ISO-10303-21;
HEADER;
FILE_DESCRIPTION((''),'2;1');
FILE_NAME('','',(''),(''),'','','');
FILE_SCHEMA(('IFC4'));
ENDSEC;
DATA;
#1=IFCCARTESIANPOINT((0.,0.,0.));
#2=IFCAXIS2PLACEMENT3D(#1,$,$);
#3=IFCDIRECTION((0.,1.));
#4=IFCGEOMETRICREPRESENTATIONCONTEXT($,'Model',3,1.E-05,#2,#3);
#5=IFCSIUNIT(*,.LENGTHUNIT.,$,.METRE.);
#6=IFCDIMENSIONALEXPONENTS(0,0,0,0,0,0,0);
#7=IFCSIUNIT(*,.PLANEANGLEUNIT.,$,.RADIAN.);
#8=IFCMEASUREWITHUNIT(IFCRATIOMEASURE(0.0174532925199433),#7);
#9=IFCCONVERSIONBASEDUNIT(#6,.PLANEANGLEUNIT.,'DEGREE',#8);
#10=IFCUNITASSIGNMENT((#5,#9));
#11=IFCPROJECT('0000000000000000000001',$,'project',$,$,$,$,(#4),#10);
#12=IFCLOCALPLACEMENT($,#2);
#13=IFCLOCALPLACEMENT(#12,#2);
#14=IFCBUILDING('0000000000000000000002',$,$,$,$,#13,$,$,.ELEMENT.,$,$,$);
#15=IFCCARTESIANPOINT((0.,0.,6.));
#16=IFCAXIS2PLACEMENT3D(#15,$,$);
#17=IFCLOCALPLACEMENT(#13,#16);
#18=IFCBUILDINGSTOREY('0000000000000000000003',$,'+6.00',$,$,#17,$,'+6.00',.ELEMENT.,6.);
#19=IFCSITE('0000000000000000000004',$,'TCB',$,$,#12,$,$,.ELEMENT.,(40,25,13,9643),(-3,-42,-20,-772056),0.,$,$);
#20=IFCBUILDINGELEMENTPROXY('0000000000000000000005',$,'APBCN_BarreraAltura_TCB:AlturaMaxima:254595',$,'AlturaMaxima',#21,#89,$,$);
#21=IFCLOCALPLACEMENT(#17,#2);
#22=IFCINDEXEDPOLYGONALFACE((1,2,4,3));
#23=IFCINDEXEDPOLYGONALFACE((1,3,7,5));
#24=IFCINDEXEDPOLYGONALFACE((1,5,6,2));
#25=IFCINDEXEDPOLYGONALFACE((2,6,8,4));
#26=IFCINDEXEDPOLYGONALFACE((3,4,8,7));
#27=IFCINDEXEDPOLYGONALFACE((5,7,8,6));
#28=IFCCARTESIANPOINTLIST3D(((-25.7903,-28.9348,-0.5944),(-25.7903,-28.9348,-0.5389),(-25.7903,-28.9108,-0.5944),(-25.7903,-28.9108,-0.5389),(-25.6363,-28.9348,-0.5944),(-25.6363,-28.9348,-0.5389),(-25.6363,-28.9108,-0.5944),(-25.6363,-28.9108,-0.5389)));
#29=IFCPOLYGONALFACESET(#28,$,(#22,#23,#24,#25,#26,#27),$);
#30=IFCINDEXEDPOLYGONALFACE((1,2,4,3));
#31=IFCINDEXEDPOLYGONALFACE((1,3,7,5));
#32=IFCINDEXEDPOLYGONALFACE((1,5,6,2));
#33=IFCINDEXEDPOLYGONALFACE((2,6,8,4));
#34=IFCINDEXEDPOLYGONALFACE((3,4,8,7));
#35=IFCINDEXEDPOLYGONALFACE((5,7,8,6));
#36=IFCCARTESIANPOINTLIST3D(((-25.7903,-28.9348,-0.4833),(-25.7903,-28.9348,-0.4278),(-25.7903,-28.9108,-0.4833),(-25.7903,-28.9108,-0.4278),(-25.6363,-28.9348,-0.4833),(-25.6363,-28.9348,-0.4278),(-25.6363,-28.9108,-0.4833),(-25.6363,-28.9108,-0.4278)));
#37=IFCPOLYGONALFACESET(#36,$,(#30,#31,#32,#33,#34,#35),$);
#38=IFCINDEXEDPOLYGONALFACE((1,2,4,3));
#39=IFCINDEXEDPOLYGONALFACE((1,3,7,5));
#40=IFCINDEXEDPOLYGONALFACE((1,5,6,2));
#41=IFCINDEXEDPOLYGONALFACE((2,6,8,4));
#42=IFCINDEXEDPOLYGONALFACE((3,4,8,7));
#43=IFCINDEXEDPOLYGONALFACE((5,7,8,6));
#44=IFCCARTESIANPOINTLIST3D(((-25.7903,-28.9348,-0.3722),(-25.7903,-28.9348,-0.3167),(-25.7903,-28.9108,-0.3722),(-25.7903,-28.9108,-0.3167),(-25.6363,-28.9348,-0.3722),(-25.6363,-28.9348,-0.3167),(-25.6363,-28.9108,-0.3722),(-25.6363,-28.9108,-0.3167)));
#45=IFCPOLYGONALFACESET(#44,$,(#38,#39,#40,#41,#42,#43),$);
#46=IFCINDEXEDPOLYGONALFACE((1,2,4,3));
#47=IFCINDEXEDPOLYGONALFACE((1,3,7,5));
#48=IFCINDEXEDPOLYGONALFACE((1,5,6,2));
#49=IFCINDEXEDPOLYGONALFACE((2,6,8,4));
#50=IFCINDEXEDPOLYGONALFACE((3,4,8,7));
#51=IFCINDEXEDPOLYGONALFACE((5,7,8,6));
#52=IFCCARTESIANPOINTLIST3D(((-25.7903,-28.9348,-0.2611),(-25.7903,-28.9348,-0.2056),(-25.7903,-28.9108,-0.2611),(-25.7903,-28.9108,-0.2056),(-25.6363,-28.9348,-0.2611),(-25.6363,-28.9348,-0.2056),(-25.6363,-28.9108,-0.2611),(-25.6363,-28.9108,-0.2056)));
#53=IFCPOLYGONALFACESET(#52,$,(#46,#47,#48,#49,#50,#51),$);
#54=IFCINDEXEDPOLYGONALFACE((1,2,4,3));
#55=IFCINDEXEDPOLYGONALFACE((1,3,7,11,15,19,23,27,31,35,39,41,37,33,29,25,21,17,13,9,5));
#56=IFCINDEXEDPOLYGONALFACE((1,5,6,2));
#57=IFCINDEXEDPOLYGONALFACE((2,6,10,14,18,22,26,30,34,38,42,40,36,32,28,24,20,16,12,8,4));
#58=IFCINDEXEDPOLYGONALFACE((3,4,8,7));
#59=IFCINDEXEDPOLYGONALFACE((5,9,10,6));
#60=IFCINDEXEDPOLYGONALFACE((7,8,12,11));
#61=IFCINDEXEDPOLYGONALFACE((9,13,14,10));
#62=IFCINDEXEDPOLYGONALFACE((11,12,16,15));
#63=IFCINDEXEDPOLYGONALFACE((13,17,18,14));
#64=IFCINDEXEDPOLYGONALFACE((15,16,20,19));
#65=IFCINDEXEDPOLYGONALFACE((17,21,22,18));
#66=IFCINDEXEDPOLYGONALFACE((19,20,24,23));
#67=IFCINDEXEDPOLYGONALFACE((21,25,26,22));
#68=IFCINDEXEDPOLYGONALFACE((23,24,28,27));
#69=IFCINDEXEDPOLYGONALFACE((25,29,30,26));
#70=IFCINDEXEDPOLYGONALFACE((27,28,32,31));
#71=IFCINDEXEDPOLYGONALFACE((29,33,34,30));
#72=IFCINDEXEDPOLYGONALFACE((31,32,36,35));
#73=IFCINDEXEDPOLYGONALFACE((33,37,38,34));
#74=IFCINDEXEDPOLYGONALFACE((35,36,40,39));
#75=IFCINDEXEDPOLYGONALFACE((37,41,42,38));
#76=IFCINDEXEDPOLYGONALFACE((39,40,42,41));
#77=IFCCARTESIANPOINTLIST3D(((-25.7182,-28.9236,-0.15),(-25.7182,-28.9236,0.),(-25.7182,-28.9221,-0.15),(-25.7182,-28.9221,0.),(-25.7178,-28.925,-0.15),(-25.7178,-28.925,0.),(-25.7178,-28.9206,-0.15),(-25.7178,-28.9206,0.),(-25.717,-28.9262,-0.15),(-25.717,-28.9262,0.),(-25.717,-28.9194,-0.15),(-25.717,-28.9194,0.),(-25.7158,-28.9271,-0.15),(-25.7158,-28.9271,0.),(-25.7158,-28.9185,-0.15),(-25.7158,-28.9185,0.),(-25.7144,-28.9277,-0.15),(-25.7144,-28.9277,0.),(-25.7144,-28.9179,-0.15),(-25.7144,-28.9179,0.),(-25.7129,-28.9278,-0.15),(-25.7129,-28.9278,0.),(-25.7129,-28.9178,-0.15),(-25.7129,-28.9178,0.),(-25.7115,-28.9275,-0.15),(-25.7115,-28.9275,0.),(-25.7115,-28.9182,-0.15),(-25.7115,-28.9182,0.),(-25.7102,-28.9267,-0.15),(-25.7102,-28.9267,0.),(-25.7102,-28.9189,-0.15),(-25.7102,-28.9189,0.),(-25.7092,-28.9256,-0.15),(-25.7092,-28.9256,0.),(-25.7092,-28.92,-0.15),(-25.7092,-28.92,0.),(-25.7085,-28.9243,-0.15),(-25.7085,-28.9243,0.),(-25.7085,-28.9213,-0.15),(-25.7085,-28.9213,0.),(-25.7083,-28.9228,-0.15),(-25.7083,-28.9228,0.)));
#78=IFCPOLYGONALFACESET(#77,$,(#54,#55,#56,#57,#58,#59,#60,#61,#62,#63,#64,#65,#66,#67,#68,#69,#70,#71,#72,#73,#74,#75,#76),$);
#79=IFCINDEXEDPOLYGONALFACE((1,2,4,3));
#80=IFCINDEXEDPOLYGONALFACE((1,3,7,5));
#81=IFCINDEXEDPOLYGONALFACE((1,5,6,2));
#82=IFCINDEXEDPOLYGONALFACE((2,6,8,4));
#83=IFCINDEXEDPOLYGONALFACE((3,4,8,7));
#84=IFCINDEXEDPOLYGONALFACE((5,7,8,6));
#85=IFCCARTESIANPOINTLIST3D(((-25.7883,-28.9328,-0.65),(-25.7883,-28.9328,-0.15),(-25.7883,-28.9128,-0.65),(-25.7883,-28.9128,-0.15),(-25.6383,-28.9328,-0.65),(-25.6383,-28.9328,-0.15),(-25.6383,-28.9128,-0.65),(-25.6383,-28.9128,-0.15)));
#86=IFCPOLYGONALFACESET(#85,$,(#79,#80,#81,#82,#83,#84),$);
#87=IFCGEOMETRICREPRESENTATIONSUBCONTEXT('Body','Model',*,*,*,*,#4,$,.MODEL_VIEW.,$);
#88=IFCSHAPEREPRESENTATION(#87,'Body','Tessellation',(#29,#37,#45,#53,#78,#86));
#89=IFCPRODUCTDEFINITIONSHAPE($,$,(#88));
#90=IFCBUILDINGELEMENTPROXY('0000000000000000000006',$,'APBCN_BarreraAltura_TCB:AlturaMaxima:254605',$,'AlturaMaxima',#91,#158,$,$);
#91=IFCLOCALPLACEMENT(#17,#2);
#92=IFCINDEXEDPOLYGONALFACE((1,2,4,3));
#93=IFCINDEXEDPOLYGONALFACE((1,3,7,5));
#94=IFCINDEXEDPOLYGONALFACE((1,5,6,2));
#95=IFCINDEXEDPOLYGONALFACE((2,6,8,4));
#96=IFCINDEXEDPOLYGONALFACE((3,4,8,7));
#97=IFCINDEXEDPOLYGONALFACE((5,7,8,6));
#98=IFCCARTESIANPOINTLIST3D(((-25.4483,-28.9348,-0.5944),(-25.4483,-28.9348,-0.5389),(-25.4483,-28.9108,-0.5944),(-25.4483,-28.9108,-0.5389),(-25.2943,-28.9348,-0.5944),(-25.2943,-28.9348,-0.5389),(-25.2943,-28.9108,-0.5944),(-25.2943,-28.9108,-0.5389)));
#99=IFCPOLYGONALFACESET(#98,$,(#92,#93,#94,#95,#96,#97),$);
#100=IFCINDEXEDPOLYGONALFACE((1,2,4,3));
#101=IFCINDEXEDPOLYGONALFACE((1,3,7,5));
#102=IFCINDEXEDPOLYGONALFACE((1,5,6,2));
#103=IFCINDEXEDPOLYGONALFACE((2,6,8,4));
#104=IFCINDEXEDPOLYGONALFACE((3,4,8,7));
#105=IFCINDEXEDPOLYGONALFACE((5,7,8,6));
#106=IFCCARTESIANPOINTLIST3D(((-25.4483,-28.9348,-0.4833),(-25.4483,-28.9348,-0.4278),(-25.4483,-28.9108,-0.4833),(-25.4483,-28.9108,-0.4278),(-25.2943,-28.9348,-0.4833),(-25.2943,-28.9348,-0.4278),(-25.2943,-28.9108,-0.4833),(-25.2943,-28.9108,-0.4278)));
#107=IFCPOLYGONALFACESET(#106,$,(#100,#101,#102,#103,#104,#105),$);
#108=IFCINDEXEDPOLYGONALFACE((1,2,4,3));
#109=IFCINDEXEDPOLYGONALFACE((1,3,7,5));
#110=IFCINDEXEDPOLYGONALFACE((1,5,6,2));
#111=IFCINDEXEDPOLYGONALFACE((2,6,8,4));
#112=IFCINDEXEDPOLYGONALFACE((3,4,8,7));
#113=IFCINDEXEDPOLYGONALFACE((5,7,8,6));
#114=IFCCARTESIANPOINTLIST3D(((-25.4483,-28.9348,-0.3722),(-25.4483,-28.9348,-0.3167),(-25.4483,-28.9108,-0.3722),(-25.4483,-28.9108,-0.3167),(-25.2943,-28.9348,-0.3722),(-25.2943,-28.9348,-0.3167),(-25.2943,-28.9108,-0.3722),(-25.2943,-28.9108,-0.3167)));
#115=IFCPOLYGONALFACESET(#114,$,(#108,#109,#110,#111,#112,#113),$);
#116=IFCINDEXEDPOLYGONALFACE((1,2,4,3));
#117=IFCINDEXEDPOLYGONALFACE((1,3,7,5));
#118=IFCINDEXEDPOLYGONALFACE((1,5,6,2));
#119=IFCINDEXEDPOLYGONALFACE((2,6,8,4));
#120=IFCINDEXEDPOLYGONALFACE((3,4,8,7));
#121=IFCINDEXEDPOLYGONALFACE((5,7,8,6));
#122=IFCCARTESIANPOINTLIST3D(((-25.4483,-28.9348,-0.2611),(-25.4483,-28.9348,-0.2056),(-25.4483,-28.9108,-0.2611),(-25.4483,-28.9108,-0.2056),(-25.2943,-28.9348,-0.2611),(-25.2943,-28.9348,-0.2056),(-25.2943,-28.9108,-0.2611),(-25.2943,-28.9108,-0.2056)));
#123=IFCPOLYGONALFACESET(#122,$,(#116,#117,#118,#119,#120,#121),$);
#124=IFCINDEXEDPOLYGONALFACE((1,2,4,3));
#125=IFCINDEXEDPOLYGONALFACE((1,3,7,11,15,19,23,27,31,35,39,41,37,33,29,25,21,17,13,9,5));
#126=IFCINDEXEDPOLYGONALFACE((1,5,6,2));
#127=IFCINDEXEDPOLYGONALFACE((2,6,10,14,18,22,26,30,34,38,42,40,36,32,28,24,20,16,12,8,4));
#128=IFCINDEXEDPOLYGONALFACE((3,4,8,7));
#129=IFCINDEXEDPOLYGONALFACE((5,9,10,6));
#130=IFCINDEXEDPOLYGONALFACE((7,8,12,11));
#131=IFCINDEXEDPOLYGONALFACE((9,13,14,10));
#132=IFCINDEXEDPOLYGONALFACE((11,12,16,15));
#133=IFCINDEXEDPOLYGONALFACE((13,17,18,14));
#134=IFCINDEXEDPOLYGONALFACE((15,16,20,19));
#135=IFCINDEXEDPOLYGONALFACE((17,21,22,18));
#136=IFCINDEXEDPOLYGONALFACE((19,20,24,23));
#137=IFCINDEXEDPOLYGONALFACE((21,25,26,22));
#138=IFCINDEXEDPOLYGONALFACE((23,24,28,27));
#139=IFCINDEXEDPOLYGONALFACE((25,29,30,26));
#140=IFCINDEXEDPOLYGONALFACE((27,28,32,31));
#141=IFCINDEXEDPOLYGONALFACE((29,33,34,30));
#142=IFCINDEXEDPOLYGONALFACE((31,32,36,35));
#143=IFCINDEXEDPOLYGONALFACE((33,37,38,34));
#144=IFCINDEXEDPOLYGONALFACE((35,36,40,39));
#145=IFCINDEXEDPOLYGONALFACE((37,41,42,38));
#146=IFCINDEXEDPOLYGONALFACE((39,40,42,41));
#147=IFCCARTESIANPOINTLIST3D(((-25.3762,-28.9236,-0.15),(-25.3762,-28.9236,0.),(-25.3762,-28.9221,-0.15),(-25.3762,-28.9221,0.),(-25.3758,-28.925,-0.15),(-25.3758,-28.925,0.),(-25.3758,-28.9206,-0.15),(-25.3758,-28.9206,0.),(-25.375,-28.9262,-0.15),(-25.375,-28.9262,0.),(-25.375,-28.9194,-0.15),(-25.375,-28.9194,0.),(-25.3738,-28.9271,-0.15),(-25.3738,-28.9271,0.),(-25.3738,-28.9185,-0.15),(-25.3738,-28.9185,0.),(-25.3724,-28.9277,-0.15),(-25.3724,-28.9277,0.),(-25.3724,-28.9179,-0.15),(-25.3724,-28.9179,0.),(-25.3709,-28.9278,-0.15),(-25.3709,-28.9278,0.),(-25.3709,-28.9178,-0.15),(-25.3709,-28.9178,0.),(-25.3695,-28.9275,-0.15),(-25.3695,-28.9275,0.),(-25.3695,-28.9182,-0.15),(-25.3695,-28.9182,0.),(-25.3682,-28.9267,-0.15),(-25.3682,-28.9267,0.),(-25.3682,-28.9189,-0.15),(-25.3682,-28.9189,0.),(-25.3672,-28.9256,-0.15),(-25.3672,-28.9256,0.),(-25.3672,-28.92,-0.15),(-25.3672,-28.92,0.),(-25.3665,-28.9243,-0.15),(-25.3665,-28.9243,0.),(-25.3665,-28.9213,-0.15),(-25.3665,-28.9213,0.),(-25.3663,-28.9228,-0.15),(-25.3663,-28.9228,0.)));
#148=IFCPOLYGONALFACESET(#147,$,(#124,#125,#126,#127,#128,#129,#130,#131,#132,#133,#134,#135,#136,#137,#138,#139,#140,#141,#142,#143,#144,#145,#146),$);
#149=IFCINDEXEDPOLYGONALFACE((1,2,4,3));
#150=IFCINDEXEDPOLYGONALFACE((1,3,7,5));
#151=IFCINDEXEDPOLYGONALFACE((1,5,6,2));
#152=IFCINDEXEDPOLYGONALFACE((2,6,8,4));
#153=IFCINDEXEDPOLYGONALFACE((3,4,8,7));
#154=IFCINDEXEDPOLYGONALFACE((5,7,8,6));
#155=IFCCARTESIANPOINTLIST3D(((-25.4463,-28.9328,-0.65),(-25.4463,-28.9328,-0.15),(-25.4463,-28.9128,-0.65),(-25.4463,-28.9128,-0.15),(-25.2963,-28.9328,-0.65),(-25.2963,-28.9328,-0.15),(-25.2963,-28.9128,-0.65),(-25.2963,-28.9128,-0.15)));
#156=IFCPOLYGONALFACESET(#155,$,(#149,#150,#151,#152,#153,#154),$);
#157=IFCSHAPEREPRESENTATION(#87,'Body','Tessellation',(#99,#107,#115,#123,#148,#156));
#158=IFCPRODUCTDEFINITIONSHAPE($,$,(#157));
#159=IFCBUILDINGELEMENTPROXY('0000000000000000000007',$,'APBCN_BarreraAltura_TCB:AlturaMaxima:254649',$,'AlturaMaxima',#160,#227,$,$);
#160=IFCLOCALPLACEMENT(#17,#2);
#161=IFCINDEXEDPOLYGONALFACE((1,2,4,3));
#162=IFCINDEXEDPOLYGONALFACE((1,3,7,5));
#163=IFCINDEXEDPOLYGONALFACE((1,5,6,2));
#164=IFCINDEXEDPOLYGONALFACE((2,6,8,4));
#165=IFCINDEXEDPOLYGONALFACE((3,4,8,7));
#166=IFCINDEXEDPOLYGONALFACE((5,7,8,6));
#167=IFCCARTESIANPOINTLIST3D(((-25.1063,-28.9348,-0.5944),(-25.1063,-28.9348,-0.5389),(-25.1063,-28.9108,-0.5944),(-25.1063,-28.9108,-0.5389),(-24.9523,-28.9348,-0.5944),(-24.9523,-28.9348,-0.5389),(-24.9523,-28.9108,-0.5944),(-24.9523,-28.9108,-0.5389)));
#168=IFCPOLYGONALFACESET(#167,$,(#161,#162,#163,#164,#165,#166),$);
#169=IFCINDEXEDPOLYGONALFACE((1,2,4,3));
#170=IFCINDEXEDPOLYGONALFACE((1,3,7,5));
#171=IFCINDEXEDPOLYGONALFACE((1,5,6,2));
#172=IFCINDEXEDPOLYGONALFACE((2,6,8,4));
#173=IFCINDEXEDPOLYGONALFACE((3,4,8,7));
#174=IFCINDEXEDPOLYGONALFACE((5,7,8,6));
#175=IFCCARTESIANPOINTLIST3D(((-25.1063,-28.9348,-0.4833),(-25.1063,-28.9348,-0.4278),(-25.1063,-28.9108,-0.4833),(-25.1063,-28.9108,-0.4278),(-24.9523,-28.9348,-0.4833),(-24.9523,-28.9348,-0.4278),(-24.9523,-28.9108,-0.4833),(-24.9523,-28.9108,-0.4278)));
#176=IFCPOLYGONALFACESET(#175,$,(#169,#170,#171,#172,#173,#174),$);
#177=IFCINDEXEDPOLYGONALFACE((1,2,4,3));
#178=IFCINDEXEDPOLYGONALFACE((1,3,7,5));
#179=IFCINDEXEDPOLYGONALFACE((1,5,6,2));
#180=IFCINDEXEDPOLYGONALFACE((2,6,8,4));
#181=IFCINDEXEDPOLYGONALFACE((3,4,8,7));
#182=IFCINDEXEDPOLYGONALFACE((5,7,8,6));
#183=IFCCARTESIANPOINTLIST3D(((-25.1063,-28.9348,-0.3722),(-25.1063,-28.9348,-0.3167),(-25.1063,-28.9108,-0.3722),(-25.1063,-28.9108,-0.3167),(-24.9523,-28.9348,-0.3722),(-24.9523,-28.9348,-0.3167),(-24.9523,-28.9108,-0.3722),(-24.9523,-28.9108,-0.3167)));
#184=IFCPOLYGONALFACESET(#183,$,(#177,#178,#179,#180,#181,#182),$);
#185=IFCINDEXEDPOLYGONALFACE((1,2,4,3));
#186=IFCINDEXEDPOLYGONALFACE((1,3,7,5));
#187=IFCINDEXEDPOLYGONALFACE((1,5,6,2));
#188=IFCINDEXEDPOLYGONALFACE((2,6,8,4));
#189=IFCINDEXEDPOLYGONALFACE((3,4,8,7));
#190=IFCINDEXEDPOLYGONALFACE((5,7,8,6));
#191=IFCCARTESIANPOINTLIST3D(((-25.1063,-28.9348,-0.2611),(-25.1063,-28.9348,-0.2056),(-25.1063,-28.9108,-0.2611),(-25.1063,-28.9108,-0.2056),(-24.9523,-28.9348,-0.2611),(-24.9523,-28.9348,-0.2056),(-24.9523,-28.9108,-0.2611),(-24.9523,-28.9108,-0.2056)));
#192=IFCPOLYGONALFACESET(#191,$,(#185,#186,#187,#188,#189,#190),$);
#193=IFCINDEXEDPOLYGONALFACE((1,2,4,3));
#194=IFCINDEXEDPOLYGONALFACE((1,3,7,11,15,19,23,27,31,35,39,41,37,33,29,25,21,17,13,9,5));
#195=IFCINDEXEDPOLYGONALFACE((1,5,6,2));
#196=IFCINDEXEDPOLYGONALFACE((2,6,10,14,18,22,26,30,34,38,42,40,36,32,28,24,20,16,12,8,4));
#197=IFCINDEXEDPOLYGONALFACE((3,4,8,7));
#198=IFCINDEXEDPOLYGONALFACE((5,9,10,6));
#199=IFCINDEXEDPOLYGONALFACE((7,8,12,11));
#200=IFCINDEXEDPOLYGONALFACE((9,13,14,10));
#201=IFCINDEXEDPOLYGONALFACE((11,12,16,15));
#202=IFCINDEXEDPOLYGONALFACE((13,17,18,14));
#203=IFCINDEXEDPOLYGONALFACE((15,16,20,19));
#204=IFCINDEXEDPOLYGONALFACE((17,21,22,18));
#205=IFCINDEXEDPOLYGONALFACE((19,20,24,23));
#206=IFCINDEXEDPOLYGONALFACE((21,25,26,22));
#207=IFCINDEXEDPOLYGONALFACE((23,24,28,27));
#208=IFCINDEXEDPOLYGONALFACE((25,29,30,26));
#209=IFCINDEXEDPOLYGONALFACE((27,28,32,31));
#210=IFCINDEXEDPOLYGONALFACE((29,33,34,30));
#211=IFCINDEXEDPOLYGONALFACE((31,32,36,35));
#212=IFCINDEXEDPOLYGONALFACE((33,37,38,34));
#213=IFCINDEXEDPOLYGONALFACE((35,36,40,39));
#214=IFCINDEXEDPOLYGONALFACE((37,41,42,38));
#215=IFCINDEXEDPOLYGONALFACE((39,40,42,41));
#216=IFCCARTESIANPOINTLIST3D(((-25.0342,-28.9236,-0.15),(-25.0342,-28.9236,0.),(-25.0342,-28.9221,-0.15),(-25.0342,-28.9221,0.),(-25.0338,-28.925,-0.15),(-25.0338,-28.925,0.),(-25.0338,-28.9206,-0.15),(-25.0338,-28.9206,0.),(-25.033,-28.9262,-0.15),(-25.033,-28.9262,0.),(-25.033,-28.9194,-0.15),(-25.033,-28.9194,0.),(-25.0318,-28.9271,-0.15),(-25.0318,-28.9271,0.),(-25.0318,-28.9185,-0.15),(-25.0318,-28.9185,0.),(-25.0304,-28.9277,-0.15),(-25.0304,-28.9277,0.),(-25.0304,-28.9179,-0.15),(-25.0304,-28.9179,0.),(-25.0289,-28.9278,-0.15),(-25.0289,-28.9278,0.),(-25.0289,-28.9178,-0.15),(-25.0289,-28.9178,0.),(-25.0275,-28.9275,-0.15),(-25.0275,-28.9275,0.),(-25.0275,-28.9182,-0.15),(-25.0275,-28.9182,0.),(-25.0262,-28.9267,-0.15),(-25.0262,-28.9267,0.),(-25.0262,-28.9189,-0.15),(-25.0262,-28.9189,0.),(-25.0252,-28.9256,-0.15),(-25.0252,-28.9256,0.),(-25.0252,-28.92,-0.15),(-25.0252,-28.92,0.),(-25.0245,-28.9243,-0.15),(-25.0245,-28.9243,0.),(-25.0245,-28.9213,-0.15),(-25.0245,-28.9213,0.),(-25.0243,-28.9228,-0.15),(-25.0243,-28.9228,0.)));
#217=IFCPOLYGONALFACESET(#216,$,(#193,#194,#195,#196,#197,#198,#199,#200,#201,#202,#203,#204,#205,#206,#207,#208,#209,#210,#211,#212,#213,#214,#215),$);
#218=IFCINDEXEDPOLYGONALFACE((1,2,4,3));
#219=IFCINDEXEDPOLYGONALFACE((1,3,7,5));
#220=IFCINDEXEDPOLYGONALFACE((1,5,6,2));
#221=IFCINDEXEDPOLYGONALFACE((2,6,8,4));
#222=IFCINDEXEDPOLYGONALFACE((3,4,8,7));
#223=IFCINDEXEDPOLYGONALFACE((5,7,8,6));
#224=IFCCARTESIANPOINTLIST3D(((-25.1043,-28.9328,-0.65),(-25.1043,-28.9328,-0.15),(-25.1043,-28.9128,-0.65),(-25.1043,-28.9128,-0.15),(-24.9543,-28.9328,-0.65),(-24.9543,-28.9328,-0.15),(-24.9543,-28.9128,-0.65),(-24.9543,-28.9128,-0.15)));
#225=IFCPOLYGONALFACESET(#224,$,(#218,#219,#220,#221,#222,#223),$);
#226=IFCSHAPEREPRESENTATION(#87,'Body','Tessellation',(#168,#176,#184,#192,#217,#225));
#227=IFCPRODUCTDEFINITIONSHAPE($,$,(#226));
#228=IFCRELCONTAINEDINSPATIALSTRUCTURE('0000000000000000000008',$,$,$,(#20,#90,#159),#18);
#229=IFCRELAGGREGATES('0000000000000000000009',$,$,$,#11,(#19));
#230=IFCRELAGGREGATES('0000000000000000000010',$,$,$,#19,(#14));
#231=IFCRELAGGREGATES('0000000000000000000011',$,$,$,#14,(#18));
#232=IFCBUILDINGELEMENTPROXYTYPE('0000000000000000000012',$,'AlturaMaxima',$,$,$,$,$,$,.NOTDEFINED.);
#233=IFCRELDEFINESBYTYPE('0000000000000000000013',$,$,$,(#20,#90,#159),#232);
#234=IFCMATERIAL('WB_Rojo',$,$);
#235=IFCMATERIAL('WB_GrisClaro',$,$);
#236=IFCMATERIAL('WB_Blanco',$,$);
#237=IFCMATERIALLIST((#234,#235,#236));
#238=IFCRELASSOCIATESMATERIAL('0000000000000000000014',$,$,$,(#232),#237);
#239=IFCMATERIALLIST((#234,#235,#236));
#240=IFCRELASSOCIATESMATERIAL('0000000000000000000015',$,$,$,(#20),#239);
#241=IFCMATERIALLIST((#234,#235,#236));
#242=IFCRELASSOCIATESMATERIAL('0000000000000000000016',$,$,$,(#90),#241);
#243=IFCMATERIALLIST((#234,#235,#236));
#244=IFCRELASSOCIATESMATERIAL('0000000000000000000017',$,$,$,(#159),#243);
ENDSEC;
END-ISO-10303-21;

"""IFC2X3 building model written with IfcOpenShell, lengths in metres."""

from ifc_helpers import new_model, entity, si_unit, converted_unit, direction, frame, frame_2d, origin, origin_2d_with_axis, place, context, subcontext, project, spatial, rectangle, circle, extrude, source, transform, mapped, material, material_list, type_object, type_shapes, element, save


model = new_model("IFC2X3")

# Units and contexts
model_context = context("Model", 3, precision=1e-05, world=origin(), true_north=direction((0.0, 1.0)))
body_context = subcontext(model_context, "Body", "Model", "MODEL_VIEW")
ifc_project = project(units=[si_unit("LENGTHUNIT", "METRE"), converted_unit("PLANEANGLEUNIT", "DEGREE", entity("IfcRatioMeasure", 0.0174532925199433), si_unit("PLANEANGLEUNIT", "RADIAN"), dimensions=[0, 0, 0, 0, 0, 0, 0])], contexts=[model_context])

# Site, building, storey
site_placement = place(None, origin())
site = spatial("IfcSite", under=ifc_project, at=site_placement, Name="TCB", CompositionType="ELEMENT", RefLatitude=(40, 25, 13, 9643), RefLongitude=(-3, -42, -20, -772056), RefElevation=0.0)
building_placement = place(site_placement, origin())
building = spatial("IfcBuilding", under=site, at=building_placement, CompositionType="ELEMENT")
storey_placement = place(building_placement, frame((0.0, 0.0, 6.0)))
storey = spatial("IfcBuildingStorey", under=building, at=storey_placement, Name="+6.00", LongName="+6.00", CompositionType="ELEMENT", Elevation=6.0)

# Building element proxies
ifc_material_1 = material(Name="WB_Rojo")
ifc_material_2 = material(Name="WB_GrisClaro")
ifc_material_3 = material(Name="WB_Blanco")
ifc_material_list_1 = material_list([ifc_material_1, ifc_material_2, ifc_material_3])
building_element_proxy_type = type_object("IfcBuildingElementProxyType", Name="AlturaMaxima", PredefinedType="NOTDEFINED", material=ifc_material_list_1)
shared_shape = source(origin(), body_context, "Body", "SweptSolid", [
    extrude(rectangle(XDim=0.154, YDim=0.024, at=frame_2d((0.0, 0.0), x_axis=(1.0, 0.0))), frame((0.0, 0.0, -0.5944), z_axis=(0.0, 0.0, 1.0), x_axis=(-1.0, 0.0, 0.0)), (0.0, 0.0, 1.0), 0.0556),
    extrude(rectangle(XDim=0.154, YDim=0.024, at=frame_2d((0.0, 0.0), x_axis=(1.0, 0.0))), frame((0.0, 0.0, -0.4833), z_axis=(0.0, 0.0, 1.0), x_axis=(-1.0, 0.0, 0.0)), (0.0, 0.0, 1.0), 0.0556),
    extrude(rectangle(XDim=0.154, YDim=0.024, at=frame_2d((0.0, 0.0), x_axis=(1.0, 0.0))), frame((0.0, 0.0, -0.3722), z_axis=(0.0, 0.0, 1.0), x_axis=(-1.0, 0.0, 0.0)), (0.0, 0.0, 1.0), 0.0556),
    extrude(rectangle(XDim=0.154, YDim=0.024, at=frame_2d((0.0, 0.0), x_axis=(1.0, 0.0))), frame((0.0, 0.0, -0.2611), z_axis=(0.0, 0.0, 1.0), x_axis=(-1.0, 0.0, 0.0)), (0.0, 0.0, 1.0), 0.0556),
    extrude(circle(Radius=0.005, at=frame_2d((0.0, 0.0), x_axis=(1.0, 0.0))), frame((0.0, 0.0, -0.15)), (0.0, 0.0, 1.0), 0.15),
    extrude(rectangle(XDim=0.02, YDim=0.15, at=origin_2d_with_axis()), frame((0.0, 0.0, -0.65), z_axis=(0.0, 0.0, 1.0), x_axis=(0.0, 1.0, 0.0)), (0.0, 0.0, 1.0), 0.5),
])
type_shapes(building_element_proxy_type, [shared_shape])
ifc_material_list_2 = material_list([ifc_material_1, ifc_material_2, ifc_material_3])
proxy_1_placement = place(storey_placement, frame((-25.7133, -28.9228, 0.0)))
element("IfcBuildingElementProxy", 1, at=proxy_1_placement, inside=storey, type_object=building_element_proxy_type, material=ifc_material_list_2, Name="APBCN_BarreraAltura_TCB:AlturaMaxima:254595", ObjectType="AlturaMaxima", context=body_context, shape_type="MappedRepresentation", body=[
    mapped(shared_shape, transform((0.0, 0.0, 0.0), scale=1.0)),
])
ifc_material_list_3 = material_list([ifc_material_1, ifc_material_2, ifc_material_3])
proxy_2_placement = place(storey_placement, frame((-25.3713, -28.9228, 0.0)))
element("IfcBuildingElementProxy", 2, at=proxy_2_placement, inside=storey, type_object=building_element_proxy_type, material=ifc_material_list_3, Name="APBCN_BarreraAltura_TCB:AlturaMaxima:254605", ObjectType="AlturaMaxima", context=body_context, shape_type="MappedRepresentation", body=[
    mapped(shared_shape, transform((0.0, 0.0, 0.0), scale=1.0)),
])
ifc_material_list_4 = material_list([ifc_material_1, ifc_material_2, ifc_material_3])
proxy_3_placement = place(storey_placement, frame((-25.0293, -28.9228, 0.0)))
element("IfcBuildingElementProxy", 3, at=proxy_3_placement, inside=storey, type_object=building_element_proxy_type, material=ifc_material_list_4, Name="APBCN_BarreraAltura_TCB:AlturaMaxima:254649", ObjectType="AlturaMaxima", context=body_context, shape_type="MappedRepresentation", body=[
    mapped(shared_shape, transform((0.0, 0.0, 0.0), scale=1.0)),
])

save(model, "model.ifc")
